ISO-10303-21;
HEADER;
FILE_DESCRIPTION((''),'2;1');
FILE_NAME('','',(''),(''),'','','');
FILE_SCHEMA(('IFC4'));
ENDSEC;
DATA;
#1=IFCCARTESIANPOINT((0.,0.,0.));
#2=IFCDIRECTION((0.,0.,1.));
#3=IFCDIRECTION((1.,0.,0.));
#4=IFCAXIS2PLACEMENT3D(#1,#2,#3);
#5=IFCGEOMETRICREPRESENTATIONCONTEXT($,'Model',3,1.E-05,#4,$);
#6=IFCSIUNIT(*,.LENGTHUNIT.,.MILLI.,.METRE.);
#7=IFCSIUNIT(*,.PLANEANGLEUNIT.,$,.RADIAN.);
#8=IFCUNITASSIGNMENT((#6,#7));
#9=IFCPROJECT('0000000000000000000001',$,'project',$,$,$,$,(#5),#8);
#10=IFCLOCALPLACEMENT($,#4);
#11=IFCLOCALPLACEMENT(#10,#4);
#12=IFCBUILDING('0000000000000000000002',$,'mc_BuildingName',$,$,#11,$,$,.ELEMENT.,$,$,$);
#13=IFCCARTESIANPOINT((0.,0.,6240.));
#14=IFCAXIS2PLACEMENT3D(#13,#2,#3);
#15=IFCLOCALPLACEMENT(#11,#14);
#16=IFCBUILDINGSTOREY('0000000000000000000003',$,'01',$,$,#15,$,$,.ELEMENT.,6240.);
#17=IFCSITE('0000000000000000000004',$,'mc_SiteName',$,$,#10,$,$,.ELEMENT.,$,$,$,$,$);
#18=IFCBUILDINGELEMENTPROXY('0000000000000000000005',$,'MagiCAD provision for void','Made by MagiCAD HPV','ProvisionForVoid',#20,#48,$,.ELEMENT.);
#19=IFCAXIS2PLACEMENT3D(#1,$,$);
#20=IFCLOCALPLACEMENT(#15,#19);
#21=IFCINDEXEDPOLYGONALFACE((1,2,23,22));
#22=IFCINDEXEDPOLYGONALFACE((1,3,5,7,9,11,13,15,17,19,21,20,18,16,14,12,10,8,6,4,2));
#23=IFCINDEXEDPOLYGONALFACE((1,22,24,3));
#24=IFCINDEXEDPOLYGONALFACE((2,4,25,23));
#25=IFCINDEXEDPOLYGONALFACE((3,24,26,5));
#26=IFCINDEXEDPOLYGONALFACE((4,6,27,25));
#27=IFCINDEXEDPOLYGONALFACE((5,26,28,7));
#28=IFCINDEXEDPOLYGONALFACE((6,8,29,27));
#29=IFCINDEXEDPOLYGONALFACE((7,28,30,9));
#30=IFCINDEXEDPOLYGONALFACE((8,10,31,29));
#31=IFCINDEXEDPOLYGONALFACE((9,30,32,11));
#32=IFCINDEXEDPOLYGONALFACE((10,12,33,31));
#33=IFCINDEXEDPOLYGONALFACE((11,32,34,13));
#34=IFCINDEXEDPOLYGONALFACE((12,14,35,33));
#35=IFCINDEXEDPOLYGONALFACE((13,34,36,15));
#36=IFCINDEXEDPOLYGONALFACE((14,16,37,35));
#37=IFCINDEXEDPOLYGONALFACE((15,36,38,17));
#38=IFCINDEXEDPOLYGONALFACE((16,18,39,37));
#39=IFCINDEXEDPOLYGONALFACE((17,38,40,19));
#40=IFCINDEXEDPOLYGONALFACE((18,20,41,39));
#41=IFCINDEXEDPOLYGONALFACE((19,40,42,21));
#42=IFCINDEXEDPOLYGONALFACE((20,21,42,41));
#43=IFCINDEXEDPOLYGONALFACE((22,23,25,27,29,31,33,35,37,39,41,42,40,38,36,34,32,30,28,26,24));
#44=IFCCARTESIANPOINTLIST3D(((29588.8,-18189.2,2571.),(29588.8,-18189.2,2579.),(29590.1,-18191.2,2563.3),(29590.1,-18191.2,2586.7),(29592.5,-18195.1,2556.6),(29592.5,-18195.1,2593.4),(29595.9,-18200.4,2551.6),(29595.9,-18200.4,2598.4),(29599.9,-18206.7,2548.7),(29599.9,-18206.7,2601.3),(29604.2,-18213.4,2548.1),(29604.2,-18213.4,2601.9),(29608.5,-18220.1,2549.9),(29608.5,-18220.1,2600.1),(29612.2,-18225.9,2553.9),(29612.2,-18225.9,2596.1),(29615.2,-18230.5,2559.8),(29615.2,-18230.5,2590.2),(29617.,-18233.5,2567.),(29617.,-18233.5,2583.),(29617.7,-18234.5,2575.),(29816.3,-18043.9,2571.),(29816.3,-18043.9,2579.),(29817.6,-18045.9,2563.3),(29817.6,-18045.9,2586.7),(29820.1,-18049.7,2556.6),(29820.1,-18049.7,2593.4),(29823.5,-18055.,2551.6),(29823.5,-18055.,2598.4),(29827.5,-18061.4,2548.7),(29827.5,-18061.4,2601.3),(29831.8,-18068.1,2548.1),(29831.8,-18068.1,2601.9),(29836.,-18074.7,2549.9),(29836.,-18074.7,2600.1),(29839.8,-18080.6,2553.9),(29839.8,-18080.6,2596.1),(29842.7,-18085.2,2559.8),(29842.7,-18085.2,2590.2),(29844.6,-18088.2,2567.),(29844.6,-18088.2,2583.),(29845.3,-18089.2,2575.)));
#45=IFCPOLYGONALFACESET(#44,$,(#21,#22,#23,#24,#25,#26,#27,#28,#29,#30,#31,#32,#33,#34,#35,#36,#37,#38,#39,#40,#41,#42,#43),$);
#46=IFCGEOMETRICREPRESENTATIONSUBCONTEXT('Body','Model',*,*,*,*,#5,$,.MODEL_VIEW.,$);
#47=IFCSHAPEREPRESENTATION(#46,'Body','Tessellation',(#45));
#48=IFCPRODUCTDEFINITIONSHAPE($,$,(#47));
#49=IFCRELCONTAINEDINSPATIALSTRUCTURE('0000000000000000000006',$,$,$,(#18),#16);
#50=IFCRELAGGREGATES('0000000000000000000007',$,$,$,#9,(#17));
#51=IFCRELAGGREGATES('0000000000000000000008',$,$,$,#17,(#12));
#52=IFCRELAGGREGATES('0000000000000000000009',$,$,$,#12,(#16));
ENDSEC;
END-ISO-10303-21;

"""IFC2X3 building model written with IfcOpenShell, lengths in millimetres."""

from ifc_helpers import new_model, si_unit, frame, origin_with_axes, origin_2d_with_axis, place, context, subcontext, project, spatial, circle, extrude, source, transform, mapped, element, save


model = new_model("IFC2X3")

# Units and contexts
model_context = context("Model", 3, precision=1e-05, world=origin_with_axes())
body_context = subcontext(model_context, "Body", "Model", "MODEL_VIEW")
ifc_project = project(units=[si_unit("LENGTHUNIT", "METRE", prefix="MILLI"), si_unit("PLANEANGLEUNIT", "RADIAN")], contexts=[model_context])

# Site, building, storey
site_placement = place(None, origin_with_axes())
site = spatial("IfcSite", under=ifc_project, at=site_placement, Name="mc_SiteName", CompositionType="ELEMENT")
building_placement = place(site_placement, origin_with_axes())
building = spatial("IfcBuilding", under=site, at=building_placement, Name="mc_BuildingName", CompositionType="ELEMENT")
storey_placement = place(building_placement, frame((0.0, 0.0, 6240.0), z_axis=(0.0, 0.0, 1.0), x_axis=(1.0, 0.0, 0.0)))
storey = spatial("IfcBuildingStorey", under=building, at=storey_placement, Name="01", CompositionType="ELEMENT", Elevation=6240.0)

# Building element proxy
shared_shape_1 = source(origin_with_axes(), body_context, "Body", "SweptSolid", [
    extrude(circle(Radius=27.0, at=origin_2d_with_axis()), frame((0.0, 0.0, 0.0), z_axis=(1.0, 0.0, 0.0), x_axis=(0.0, 1.0, 0.0)), (0.0, 0.0, 1.0), 270.0),
])
proxy_1_placement = place(storey_placement, frame((29830.7, -18066.4, 2575.0), z_axis=(0.0, 0.0, 1.0), x_axis=(-0.842809, -0.538213, 0.0)))
element("IfcBuildingElementProxy", 1, at=proxy_1_placement, inside=storey, Name="MagiCAD provision for void", Description="Made by MagiCAD HPV", ObjectType="ProvisionForVoid", CompositionType="ELEMENT", context=body_context, shape_type="MappedRepresentation", body=[
    mapped(shared_shape_1, transform((0.0, 0.0, 0.0), scale=1.0)),
])

save(model, "model.ifc")
